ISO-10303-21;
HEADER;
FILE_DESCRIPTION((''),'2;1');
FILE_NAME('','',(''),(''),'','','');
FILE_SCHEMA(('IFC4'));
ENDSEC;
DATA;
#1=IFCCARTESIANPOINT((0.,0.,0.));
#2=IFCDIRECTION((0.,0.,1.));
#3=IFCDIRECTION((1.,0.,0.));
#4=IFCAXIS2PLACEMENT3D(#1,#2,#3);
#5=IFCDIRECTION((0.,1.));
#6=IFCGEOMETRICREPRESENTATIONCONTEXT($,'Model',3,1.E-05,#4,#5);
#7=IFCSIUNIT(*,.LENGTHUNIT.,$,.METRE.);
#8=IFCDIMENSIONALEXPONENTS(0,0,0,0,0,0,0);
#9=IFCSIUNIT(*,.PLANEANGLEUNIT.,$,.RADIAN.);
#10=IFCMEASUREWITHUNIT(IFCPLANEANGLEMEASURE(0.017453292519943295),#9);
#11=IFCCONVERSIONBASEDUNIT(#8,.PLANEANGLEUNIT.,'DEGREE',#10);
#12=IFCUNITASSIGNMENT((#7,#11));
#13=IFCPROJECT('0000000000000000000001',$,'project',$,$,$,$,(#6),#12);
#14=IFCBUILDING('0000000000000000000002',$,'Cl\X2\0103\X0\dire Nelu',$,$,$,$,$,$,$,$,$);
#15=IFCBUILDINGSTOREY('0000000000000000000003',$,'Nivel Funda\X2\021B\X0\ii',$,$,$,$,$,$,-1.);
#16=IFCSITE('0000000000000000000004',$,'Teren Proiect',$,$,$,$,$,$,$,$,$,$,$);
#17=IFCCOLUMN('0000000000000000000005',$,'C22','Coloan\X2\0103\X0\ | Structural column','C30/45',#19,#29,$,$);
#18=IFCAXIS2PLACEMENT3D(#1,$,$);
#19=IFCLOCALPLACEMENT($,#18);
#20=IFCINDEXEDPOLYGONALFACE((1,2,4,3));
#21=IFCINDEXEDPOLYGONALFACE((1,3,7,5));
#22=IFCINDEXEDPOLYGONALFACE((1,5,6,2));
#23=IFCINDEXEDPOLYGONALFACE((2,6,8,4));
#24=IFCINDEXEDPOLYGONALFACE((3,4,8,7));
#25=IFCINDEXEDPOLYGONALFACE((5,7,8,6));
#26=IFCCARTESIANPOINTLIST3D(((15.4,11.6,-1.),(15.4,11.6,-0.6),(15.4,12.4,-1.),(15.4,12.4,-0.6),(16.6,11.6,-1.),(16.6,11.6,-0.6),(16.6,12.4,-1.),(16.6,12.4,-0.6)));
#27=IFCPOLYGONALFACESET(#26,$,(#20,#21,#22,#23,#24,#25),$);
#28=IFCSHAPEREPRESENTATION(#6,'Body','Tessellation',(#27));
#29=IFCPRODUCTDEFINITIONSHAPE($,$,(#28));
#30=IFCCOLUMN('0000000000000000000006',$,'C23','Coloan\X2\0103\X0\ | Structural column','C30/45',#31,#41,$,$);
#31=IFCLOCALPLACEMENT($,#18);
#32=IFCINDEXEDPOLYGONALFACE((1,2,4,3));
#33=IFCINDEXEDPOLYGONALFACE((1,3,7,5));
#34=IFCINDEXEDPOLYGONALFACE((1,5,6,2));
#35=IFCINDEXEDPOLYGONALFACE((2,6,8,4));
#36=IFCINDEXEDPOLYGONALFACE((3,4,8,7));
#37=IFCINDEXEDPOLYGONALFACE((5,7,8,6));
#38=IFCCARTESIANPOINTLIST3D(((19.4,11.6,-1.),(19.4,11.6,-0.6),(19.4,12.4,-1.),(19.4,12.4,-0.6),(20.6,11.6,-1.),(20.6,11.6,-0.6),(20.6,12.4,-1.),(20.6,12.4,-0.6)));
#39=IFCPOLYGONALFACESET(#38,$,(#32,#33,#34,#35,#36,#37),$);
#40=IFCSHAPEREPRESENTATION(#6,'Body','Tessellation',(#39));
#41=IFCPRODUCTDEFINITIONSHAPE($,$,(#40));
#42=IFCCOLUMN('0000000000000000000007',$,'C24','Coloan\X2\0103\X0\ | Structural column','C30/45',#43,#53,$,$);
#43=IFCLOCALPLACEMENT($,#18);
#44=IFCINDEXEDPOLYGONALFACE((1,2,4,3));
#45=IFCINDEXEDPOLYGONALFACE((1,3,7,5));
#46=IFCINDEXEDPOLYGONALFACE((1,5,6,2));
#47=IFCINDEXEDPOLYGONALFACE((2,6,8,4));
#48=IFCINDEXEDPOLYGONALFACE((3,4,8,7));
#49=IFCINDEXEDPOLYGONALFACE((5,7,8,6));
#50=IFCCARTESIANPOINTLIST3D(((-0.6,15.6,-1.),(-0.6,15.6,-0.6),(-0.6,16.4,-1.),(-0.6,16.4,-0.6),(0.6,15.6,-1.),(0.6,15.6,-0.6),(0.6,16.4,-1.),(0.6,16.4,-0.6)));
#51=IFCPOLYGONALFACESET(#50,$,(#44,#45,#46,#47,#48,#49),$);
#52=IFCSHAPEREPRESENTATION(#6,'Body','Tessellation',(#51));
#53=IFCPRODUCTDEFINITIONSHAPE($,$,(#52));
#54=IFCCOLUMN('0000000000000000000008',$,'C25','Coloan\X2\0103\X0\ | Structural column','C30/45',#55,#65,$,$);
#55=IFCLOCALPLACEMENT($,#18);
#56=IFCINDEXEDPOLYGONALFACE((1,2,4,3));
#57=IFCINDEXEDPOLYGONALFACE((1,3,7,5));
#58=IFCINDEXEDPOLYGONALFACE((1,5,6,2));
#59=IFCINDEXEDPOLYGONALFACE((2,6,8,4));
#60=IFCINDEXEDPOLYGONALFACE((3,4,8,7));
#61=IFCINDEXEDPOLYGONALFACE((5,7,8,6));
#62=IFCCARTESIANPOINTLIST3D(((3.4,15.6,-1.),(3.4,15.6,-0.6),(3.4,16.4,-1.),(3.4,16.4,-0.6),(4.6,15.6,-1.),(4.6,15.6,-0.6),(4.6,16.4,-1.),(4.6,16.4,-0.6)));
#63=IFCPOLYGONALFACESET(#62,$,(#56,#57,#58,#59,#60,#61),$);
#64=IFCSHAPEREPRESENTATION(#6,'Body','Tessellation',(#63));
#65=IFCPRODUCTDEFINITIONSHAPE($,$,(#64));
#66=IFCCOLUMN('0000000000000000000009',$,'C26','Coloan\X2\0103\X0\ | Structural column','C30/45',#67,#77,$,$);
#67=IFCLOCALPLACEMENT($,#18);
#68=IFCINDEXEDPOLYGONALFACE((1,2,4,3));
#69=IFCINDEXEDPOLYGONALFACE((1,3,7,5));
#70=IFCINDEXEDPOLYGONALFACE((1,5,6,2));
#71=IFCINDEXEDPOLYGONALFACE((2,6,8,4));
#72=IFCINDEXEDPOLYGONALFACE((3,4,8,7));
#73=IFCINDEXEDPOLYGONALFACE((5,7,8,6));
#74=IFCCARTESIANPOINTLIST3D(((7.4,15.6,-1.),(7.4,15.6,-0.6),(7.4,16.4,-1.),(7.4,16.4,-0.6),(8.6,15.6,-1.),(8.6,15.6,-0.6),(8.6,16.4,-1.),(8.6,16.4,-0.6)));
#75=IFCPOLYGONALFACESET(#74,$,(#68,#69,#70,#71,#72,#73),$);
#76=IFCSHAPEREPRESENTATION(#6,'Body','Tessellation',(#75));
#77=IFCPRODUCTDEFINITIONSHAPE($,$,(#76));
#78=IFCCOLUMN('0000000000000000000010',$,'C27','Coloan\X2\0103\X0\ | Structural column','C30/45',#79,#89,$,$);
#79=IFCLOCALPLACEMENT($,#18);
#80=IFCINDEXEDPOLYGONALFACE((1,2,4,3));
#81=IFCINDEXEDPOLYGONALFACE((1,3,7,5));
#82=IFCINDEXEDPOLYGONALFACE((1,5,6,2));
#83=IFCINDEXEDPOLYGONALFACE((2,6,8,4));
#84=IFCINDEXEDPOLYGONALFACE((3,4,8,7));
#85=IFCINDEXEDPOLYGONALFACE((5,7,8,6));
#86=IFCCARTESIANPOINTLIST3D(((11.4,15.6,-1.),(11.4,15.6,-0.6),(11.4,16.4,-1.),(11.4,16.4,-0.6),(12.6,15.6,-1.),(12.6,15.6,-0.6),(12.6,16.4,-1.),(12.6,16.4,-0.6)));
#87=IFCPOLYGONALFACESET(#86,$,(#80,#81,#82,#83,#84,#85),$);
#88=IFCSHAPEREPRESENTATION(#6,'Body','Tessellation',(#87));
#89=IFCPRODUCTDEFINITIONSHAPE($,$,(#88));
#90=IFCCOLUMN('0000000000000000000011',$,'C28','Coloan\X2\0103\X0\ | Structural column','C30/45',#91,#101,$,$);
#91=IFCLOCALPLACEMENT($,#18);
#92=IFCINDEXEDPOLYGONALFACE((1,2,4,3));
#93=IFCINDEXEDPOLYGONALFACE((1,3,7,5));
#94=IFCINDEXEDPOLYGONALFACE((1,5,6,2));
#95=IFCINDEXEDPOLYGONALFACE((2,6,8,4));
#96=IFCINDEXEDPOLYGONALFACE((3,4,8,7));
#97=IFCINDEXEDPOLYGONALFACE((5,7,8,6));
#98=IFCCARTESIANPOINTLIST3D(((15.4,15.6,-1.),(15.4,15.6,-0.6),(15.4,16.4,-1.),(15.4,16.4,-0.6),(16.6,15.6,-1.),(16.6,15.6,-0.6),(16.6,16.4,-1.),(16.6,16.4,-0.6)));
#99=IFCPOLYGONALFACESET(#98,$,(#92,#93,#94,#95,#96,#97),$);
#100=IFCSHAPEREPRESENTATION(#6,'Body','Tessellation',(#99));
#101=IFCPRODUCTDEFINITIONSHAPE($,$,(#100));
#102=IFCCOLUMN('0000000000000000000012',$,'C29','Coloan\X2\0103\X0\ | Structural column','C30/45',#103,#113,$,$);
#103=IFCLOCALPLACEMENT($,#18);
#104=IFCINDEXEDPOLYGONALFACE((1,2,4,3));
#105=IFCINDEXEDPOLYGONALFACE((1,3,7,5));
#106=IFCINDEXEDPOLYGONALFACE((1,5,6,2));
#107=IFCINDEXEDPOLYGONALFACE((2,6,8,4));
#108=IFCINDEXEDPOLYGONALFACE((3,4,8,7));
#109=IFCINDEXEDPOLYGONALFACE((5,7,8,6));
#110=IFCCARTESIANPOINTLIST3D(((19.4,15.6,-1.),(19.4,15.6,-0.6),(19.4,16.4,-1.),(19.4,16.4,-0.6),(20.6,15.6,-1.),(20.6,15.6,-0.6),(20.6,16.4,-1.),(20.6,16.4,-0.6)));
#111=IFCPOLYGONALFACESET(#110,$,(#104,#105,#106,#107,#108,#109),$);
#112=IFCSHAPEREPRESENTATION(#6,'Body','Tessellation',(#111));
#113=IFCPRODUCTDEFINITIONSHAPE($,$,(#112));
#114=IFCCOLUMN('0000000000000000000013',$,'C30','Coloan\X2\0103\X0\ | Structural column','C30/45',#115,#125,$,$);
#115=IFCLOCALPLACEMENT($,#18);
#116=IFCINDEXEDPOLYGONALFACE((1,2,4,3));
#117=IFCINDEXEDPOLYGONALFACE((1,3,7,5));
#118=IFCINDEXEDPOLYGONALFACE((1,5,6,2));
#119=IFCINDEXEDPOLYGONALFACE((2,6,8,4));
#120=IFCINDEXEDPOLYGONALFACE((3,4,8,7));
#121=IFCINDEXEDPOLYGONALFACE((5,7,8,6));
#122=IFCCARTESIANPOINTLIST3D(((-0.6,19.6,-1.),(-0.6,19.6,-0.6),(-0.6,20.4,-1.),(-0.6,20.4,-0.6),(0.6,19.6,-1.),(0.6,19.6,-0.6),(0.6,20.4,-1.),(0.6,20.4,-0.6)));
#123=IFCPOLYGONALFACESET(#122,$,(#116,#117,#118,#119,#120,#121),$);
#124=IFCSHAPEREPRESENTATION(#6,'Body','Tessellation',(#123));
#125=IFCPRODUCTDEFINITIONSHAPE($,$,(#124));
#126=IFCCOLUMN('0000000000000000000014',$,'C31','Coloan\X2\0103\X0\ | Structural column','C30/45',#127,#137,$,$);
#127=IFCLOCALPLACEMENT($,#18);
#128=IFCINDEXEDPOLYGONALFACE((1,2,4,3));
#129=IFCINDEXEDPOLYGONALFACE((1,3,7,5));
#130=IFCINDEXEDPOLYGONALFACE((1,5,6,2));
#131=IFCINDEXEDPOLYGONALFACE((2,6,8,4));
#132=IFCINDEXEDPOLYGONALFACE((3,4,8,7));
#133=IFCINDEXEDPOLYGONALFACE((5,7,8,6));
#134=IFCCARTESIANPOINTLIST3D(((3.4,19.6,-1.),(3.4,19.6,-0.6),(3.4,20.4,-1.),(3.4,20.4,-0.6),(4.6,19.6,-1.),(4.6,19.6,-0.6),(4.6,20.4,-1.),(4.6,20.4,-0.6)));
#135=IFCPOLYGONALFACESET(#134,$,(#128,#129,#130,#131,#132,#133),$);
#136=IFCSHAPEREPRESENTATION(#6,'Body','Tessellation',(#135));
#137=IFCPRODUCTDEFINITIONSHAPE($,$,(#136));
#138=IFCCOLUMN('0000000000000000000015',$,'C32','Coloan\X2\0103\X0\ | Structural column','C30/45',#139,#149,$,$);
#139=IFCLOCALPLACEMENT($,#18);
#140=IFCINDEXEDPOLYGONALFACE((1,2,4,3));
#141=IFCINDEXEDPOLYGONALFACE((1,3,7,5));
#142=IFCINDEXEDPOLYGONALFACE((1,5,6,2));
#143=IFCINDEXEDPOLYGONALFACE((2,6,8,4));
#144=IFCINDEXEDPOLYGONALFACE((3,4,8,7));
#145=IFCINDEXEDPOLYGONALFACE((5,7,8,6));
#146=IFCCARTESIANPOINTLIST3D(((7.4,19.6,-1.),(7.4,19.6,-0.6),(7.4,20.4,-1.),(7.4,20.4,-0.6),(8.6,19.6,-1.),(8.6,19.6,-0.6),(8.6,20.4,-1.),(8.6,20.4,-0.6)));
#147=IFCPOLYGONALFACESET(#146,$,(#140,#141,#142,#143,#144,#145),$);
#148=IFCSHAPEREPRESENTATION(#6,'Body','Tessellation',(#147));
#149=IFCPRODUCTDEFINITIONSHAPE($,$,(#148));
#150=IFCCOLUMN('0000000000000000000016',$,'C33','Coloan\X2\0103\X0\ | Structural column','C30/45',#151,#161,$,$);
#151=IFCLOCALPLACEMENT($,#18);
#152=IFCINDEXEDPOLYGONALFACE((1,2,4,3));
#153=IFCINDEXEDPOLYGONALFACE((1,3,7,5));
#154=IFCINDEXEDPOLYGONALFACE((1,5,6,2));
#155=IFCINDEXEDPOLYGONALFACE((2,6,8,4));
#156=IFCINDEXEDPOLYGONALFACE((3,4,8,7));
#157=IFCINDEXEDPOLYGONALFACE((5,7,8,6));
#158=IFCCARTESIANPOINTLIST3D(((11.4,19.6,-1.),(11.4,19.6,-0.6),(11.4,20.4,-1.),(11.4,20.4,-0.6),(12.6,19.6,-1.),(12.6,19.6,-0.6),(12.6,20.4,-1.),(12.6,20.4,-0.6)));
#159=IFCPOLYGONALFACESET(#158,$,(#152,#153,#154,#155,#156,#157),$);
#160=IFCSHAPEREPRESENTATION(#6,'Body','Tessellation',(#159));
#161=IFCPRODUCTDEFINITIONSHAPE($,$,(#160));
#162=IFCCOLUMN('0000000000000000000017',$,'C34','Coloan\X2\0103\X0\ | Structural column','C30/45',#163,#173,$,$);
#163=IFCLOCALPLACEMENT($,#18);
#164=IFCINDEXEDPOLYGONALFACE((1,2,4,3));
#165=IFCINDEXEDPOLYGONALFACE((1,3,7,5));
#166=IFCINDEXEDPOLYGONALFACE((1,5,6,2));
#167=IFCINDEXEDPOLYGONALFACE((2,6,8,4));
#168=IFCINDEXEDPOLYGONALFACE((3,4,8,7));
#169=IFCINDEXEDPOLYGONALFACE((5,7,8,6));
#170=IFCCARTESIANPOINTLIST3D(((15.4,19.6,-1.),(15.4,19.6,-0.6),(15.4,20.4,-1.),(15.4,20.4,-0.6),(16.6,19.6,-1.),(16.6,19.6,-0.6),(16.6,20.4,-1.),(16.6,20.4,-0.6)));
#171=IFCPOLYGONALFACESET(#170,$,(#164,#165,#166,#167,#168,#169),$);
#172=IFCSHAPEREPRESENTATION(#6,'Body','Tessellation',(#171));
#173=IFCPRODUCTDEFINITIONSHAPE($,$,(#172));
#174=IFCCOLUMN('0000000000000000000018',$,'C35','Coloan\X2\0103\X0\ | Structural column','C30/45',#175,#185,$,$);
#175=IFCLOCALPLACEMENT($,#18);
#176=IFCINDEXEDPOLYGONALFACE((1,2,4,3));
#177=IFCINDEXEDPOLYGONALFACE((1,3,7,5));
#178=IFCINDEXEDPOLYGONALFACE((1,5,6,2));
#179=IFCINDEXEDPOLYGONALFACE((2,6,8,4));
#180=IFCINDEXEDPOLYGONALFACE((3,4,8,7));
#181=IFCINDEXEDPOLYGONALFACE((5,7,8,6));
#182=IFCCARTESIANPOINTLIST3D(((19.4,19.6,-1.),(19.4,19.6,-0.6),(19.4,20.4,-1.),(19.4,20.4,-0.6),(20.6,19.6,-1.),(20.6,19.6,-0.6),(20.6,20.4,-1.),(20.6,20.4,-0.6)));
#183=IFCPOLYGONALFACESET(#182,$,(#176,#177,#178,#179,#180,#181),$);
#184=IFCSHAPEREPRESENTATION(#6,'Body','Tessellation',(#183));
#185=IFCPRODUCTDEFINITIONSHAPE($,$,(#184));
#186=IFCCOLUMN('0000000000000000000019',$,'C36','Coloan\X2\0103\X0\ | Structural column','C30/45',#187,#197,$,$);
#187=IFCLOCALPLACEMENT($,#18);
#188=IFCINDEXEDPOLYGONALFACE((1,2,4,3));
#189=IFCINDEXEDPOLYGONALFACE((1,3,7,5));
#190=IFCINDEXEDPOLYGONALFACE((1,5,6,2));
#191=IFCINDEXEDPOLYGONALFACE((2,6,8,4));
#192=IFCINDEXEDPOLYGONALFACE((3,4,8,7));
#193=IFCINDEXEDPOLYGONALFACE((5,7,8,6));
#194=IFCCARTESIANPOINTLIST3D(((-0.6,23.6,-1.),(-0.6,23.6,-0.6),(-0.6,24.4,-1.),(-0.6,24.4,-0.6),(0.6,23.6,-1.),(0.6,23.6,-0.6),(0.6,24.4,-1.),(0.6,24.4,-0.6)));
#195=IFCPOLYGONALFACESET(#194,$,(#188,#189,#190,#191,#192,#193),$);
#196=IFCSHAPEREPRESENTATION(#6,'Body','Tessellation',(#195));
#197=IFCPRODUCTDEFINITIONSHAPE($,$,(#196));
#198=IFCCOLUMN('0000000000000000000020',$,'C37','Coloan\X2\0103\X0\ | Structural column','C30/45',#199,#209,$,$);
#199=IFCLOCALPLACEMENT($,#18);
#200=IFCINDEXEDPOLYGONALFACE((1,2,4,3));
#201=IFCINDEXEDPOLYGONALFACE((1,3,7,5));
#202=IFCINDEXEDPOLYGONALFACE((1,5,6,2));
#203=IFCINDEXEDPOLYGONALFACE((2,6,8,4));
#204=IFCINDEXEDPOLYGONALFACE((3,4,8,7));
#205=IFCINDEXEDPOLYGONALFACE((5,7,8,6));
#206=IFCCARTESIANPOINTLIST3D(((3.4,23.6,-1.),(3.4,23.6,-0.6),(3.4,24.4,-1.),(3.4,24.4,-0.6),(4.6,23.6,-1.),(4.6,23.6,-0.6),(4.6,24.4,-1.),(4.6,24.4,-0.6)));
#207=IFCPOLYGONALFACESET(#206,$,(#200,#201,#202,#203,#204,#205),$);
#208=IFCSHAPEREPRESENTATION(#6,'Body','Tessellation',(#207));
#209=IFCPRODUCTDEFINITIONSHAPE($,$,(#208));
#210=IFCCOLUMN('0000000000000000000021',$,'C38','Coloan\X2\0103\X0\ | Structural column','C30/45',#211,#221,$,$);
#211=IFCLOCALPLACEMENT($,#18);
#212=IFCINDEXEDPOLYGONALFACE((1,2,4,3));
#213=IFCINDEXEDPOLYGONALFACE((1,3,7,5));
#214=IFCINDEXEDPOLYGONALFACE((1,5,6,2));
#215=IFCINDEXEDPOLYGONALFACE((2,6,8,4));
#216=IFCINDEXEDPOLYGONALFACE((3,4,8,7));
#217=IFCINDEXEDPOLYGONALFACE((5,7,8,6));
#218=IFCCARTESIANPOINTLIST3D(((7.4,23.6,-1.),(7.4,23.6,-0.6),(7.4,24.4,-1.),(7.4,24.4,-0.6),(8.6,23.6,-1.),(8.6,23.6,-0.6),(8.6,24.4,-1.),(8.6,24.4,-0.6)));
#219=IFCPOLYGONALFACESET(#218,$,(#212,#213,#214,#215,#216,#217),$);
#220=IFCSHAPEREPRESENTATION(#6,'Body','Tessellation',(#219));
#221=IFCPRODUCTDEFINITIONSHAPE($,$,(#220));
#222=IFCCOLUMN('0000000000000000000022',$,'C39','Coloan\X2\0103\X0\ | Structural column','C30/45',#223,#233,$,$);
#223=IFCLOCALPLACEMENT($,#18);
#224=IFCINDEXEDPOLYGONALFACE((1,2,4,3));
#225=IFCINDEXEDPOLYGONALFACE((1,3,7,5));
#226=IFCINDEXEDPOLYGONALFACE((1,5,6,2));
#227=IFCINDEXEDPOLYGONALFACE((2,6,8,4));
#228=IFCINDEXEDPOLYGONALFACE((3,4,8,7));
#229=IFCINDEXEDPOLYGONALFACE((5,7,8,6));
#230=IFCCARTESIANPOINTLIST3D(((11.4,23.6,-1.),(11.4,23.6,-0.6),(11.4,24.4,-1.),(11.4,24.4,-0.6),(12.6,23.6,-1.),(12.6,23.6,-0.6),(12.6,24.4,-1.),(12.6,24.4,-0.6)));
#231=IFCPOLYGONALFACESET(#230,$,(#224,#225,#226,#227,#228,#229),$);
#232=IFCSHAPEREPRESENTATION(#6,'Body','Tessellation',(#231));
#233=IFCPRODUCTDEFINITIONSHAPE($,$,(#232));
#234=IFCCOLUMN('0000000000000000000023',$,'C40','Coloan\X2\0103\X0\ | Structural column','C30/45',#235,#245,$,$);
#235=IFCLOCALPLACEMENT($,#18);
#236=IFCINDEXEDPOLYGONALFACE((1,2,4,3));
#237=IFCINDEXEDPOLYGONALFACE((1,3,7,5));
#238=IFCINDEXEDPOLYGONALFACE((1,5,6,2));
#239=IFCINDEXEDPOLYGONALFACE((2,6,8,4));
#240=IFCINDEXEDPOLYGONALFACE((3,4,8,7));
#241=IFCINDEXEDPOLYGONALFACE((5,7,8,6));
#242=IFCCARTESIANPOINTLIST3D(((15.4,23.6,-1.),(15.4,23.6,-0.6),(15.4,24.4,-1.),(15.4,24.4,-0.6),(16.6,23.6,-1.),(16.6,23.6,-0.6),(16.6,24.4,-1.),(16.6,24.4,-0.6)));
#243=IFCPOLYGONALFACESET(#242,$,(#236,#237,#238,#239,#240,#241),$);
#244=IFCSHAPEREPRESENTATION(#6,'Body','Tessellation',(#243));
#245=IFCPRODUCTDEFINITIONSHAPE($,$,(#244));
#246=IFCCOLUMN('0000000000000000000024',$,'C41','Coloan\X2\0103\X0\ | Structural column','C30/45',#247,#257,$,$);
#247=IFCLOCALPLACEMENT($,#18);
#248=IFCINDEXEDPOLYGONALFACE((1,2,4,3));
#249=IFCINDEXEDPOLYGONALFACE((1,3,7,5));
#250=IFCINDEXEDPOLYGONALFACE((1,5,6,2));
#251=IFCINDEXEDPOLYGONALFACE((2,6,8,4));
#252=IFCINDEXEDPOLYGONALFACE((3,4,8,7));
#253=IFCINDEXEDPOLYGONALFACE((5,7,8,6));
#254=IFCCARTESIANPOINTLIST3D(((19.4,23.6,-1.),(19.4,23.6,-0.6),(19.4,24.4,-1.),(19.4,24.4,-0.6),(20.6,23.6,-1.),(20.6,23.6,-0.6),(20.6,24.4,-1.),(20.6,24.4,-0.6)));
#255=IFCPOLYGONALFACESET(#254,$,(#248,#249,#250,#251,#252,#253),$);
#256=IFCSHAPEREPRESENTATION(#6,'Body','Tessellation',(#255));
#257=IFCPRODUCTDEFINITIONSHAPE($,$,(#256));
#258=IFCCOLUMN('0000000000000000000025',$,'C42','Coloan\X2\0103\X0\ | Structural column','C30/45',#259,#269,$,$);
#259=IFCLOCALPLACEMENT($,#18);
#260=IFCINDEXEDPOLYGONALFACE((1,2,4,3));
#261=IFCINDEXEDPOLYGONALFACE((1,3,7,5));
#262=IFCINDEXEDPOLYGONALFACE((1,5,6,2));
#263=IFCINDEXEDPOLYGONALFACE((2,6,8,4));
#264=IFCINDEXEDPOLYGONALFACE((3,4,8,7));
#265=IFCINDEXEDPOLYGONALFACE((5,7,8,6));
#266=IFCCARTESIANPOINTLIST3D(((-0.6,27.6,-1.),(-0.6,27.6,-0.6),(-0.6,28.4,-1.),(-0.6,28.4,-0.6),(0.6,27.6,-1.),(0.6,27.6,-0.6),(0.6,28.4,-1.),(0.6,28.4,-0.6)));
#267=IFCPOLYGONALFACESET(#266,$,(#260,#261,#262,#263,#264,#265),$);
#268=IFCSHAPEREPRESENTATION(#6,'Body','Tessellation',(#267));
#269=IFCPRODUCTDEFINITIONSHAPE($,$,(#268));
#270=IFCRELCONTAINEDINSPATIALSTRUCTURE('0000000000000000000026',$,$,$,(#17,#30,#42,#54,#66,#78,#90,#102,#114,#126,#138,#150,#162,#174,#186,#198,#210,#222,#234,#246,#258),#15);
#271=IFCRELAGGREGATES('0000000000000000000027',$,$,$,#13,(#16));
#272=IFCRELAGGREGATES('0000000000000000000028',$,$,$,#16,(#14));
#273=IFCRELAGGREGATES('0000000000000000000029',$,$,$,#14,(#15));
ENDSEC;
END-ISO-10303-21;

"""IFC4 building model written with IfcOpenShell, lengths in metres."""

from ifc_helpers import new_model, entity, si_unit, converted_unit, direction, frame, origin_with_axes, place, context, project, spatial, rectangle, extrude, element, save


model = new_model("IFC4")

# Units and contexts
model_context = context("Model", 3, precision=1e-05, world=origin_with_axes(), true_north=direction((0.0, 1.0)))
ifc_project = project(units=[si_unit("LENGTHUNIT", "METRE"), converted_unit("PLANEANGLEUNIT", "DEGREE", entity("IfcPlaneAngleMeasure", 0.017453292519943295), si_unit("PLANEANGLEUNIT", "RADIAN"), dimensions=[0, 0, 0, 0, 0, 0, 0])], contexts=[model_context])

# Site, building, storey
site = spatial("IfcSite", under=ifc_project, Name="Teren Proiect")
building = spatial("IfcBuilding", under=site, Name="Clădire Nelu")
storey = spatial("IfcBuildingStorey", under=building, Name="Nivel Fundații", Elevation=-1.0)

# Columns
for number, where, z_axis, x_axis, name in (
    (1, (16.0, 12.0, -1.0), (0.0, 0.0, 1.0), (1.0, 0.0, 0.0), "C22"),
    (2, (20.0, 12.0, -1.0), (0.0, 0.0, 1.0), (1.0, 0.0, 0.0), "C23"),
    (3, (0.0, 16.0, -1.0), (0.0, 0.0, 1.0), (1.0, 0.0, 0.0), "C24"),
    (4, (4.0, 16.0, -1.0), (0.0, 0.0, 1.0), (1.0, 0.0, 0.0), "C25"),
    (5, (8.0, 16.0, -1.0), (0.0, 0.0, 1.0), (1.0, 0.0, 0.0), "C26"),
    (6, (12.0, 16.0, -1.0), (0.0, 0.0, 1.0), (1.0, 0.0, 0.0), "C27"),
    (7, (16.0, 16.0, -1.0), (0.0, 0.0, 1.0), (1.0, 0.0, 0.0), "C28"),
    (8, (20.0, 16.0, -1.0), (0.0, 0.0, 1.0), (1.0, 0.0, 0.0), "C29"),
    (9, (0.0, 20.0, -1.0), (0.0, 0.0, 1.0), (1.0, 0.0, 0.0), "C30"),
    (10, (4.0, 20.0, -1.0), (0.0, 0.0, 1.0), (1.0, 0.0, 0.0), "C31"),
    (11, (8.0, 20.0, -1.0), (0.0, 0.0, 1.0), (1.0, 0.0, 0.0), "C32"),
    (12, (12.0, 20.0, -1.0), (0.0, 0.0, 1.0), (1.0, 0.0, 0.0), "C33"),
    (13, (16.0, 20.0, -1.0), (0.0, 0.0, 1.0), (1.0, 0.0, 0.0), "C34"),
    (14, (20.0, 20.0, -1.0), (0.0, 0.0, 1.0), (1.0, 0.0, 0.0), "C35"),
    (15, (0.0, 24.0, -1.0), (0.0, 0.0, 1.0), (1.0, 0.0, 0.0), "C36"),
    (16, (4.0, 24.0, -1.0), (0.0, 0.0, 1.0), (1.0, 0.0, 0.0), "C37"),
    (17, (8.0, 24.0, -1.0), (0.0, 0.0, 1.0), (1.0, 0.0, 0.0), "C38"),
    (18, (12.0, 24.0, -1.0), (0.0, 0.0, 1.0), (1.0, 0.0, 0.0), "C39"),
    (19, (16.0, 24.0, -1.0), (0.0, 0.0, 1.0), (1.0, 0.0, 0.0), "C40"),
    (20, (20.0, 24.0, -1.0), (0.0, 0.0, 1.0), (1.0, 0.0, 0.0), "C41"),
    (21, (0.0, 28.0, -1.0), (0.0, 0.0, 1.0), (1.0, 0.0, 0.0), "C42"),
):
    element("IfcColumn", number, at=place(None, frame(where, z_axis=z_axis, x_axis=x_axis)), inside=storey, Name=name, Description="Coloană | Structural column", ObjectType="C30/45", context=model_context, shape_type="SweptSolid", body=[
        extrude(rectangle(XDim=1.2, YDim=0.8), None, (0.0, 0.0, 1.0), 0.4),
    ])

save(model, "model.ifc")
